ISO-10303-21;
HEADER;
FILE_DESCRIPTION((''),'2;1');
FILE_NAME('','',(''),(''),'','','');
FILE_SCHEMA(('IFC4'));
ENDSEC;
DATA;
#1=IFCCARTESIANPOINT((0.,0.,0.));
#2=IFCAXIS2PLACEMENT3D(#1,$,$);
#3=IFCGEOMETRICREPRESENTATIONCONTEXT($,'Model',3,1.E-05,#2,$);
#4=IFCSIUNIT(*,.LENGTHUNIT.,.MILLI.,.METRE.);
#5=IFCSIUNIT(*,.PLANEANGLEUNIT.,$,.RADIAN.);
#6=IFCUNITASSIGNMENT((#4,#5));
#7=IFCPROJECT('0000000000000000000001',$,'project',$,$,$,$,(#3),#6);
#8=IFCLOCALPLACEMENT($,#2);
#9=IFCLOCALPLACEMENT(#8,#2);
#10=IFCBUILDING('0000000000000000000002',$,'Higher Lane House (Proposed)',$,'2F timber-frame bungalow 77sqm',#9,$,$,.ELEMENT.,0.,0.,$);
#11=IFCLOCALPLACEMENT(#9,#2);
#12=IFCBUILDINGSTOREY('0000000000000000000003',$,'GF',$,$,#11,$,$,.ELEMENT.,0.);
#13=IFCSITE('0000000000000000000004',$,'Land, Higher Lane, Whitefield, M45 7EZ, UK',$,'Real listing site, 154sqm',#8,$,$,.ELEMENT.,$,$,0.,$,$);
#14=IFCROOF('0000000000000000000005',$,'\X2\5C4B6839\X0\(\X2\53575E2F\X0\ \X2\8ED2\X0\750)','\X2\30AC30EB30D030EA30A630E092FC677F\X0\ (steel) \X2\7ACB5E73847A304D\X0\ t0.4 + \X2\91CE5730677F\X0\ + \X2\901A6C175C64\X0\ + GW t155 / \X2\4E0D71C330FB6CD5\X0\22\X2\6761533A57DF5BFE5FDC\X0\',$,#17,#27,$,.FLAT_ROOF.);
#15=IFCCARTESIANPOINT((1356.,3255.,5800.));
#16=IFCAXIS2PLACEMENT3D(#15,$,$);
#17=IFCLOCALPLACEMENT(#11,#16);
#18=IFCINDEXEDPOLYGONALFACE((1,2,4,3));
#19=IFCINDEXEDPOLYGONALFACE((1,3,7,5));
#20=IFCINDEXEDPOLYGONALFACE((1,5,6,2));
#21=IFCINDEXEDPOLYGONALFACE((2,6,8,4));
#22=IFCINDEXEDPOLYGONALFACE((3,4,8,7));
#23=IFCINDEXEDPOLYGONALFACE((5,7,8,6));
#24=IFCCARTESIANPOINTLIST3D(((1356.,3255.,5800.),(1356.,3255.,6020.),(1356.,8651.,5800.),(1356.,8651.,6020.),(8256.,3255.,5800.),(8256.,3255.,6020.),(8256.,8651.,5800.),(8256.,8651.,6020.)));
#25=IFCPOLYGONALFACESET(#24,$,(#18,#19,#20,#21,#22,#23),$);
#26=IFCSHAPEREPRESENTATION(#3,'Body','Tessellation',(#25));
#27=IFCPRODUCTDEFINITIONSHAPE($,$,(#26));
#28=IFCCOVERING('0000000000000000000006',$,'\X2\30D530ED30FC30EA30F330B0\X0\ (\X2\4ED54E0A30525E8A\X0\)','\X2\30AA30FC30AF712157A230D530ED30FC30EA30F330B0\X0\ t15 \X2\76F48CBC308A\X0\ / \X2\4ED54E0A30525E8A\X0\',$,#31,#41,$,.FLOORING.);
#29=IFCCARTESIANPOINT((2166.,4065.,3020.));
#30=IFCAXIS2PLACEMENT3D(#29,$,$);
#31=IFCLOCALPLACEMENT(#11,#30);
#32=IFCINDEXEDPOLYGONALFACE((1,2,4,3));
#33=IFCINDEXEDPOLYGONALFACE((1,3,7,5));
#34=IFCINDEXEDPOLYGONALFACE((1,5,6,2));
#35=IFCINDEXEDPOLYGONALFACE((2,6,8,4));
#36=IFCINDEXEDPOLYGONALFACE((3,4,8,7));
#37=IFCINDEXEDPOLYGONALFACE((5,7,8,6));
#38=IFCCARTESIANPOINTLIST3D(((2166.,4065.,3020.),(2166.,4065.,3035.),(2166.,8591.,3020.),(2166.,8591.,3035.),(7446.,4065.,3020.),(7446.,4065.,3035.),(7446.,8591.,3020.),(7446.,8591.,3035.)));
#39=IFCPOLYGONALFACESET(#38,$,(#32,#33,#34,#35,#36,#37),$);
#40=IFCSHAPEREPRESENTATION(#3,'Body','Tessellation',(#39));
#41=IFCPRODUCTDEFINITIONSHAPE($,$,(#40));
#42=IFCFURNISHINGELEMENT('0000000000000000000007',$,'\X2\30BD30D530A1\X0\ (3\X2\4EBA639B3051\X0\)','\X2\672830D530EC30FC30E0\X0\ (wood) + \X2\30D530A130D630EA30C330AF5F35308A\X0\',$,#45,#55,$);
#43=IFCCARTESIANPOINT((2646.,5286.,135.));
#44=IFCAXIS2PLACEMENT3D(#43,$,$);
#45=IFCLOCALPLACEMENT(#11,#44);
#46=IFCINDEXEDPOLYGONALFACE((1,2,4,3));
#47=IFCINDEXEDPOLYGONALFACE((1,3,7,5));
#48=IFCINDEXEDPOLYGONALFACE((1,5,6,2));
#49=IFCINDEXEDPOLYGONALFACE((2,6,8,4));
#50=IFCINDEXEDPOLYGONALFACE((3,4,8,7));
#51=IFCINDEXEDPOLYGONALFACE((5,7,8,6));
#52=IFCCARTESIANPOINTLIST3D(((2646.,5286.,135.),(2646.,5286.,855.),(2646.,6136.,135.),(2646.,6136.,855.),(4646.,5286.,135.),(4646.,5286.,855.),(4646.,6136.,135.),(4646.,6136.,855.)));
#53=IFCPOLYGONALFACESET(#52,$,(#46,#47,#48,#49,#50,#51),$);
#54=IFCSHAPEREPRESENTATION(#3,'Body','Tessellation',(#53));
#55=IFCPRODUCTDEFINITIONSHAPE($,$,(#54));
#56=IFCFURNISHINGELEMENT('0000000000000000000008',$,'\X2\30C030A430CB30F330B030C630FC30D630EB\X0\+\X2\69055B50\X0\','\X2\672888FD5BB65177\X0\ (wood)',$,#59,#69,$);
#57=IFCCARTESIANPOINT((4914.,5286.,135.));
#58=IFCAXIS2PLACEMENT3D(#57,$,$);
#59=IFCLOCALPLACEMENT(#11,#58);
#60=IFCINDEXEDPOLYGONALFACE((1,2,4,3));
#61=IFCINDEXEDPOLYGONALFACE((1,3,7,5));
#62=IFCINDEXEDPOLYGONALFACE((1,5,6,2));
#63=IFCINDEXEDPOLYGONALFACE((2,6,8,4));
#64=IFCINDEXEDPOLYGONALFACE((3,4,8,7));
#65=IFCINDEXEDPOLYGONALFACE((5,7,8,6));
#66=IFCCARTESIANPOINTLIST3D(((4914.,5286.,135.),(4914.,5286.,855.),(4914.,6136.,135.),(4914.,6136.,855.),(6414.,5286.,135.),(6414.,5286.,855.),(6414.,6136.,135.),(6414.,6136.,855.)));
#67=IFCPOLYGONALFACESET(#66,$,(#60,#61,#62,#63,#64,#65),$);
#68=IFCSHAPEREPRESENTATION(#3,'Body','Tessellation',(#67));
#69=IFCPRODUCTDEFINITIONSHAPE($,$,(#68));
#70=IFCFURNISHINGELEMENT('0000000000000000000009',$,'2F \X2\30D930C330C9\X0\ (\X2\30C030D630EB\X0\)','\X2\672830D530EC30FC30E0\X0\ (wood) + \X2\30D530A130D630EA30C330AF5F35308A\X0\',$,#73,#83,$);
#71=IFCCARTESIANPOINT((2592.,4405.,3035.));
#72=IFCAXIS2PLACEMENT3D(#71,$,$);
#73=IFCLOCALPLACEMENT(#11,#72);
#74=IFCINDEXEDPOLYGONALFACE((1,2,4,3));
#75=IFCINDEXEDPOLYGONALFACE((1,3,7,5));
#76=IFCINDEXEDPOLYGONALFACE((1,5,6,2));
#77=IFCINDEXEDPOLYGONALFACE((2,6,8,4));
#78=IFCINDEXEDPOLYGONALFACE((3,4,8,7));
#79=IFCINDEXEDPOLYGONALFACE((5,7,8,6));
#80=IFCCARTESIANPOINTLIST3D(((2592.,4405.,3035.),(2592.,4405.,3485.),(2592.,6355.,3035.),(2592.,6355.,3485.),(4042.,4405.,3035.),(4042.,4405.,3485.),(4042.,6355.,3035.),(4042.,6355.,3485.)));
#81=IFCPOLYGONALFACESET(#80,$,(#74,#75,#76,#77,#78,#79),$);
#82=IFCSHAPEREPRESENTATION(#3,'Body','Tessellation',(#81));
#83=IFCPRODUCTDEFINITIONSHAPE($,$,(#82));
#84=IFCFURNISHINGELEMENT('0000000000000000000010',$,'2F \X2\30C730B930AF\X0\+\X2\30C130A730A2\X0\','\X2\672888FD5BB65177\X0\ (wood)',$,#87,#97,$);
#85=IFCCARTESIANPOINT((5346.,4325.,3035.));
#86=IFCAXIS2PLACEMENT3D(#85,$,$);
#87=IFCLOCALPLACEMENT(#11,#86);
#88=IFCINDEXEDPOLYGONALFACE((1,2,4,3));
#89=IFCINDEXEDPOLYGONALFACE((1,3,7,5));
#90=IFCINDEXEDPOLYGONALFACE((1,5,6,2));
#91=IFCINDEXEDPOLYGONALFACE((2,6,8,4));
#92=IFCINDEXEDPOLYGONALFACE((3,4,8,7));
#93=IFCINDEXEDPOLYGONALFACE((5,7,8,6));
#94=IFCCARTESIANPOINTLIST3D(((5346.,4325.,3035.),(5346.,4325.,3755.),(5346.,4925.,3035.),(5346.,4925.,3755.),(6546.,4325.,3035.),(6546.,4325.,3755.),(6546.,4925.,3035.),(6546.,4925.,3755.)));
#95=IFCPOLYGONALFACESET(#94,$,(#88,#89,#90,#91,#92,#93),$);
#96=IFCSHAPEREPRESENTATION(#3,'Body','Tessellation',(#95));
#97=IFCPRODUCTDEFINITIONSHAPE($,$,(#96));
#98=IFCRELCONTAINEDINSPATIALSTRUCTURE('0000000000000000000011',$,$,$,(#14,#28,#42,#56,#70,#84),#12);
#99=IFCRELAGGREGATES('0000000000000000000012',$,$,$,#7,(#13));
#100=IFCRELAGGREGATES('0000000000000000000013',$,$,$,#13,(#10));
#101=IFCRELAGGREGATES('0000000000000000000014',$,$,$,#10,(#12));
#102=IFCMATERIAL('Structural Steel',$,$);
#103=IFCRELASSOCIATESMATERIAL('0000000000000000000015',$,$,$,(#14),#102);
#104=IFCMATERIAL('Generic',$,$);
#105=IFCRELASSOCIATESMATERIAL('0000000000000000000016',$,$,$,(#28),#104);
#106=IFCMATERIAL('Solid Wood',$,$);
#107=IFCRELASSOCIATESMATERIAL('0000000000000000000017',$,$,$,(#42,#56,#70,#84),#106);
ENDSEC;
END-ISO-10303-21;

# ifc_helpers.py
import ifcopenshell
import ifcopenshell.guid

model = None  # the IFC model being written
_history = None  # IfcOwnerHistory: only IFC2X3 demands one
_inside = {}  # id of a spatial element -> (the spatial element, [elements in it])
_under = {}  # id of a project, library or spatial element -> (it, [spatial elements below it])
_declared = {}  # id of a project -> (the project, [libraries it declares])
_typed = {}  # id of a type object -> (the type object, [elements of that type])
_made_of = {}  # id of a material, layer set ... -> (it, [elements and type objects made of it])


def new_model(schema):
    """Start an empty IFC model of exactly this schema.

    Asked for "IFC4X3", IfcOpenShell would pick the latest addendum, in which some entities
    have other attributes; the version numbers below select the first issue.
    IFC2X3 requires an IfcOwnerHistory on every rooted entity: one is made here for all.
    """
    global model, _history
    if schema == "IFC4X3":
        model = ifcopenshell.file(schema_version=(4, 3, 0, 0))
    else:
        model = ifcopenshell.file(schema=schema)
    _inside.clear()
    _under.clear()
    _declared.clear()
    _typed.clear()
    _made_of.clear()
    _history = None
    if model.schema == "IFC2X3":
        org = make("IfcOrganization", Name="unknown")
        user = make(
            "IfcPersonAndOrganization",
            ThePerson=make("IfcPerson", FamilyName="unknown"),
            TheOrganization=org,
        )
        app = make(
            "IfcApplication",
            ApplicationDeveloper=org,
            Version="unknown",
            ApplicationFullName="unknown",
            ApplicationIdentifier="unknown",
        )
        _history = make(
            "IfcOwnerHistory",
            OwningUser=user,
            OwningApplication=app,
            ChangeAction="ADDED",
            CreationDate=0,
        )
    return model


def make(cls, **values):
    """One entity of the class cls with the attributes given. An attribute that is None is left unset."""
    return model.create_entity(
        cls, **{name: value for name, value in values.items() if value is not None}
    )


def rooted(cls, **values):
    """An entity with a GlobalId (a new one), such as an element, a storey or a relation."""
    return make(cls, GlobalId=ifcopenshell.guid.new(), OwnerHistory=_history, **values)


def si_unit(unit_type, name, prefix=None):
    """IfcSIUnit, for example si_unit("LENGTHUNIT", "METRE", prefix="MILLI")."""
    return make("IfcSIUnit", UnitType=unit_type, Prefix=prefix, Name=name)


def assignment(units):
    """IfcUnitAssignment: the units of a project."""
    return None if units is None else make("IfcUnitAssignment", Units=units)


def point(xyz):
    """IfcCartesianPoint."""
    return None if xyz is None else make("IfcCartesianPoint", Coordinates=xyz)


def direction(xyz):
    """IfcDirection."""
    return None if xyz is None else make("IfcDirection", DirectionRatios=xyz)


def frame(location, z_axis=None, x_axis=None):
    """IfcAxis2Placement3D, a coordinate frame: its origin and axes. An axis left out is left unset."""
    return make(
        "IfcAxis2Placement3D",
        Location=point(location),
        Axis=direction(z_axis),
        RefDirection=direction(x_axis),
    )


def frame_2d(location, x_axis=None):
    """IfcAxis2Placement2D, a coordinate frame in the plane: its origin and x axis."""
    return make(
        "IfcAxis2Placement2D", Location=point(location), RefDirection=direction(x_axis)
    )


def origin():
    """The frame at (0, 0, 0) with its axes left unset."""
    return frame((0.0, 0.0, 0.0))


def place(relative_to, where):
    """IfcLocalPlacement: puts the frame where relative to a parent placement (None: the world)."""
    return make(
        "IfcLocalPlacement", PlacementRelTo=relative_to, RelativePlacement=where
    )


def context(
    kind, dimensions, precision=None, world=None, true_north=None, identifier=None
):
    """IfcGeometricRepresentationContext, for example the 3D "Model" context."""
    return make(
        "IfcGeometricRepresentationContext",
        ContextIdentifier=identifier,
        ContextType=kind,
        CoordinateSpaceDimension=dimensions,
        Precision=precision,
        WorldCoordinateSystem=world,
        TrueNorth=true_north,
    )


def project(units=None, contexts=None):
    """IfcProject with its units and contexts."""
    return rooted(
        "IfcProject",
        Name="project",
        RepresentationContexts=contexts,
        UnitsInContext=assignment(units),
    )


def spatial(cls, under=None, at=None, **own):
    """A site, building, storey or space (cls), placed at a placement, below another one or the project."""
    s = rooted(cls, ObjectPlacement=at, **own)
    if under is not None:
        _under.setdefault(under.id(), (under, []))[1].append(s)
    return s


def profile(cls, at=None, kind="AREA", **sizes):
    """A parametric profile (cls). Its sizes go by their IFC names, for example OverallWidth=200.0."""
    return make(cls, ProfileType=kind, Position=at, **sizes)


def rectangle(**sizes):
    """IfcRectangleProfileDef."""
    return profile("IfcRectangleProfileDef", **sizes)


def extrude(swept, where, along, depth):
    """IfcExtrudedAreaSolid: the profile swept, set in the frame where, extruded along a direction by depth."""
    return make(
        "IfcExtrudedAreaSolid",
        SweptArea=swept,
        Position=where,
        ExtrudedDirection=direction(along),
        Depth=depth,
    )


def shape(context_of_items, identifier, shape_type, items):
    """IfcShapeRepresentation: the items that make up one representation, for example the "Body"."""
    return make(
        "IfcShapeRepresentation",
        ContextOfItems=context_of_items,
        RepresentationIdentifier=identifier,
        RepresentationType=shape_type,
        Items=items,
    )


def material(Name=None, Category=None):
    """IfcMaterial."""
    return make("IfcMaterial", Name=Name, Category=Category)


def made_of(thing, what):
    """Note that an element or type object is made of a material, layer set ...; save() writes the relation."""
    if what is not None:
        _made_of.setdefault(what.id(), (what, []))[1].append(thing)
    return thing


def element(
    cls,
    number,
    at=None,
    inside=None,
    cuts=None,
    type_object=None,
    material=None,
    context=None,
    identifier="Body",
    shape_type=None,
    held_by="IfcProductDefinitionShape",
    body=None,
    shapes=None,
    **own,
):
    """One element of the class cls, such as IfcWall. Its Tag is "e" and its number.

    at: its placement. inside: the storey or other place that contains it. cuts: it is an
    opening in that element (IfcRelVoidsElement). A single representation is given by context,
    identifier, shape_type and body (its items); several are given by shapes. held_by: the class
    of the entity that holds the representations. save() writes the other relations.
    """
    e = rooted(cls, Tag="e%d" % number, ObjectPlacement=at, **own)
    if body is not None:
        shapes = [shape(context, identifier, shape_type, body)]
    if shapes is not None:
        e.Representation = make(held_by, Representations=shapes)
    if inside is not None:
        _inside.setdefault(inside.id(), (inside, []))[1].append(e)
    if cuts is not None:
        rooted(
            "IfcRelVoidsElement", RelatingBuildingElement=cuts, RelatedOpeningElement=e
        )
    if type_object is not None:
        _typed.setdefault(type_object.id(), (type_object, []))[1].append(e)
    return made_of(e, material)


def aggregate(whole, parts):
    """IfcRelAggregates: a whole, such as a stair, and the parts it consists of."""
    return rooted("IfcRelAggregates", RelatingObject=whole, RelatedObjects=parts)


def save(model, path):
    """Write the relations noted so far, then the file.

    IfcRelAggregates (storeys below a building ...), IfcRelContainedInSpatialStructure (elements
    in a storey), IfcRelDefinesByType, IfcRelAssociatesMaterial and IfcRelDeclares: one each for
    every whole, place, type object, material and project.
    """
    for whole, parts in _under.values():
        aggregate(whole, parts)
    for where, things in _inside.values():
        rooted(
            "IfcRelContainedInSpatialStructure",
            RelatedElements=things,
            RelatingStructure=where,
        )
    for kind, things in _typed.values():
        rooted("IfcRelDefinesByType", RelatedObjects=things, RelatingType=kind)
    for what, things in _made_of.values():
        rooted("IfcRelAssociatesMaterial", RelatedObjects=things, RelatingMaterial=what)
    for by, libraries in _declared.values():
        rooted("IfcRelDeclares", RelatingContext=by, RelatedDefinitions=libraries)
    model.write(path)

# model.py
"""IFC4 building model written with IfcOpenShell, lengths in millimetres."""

from ifc_helpers import new_model, si_unit, frame, frame_2d, origin, place, context, project, spatial, rectangle, extrude, material, element, save


model = new_model("IFC4")

# Units and contexts
model_context = context("Model", 3, precision=1e-05, world=origin())
ifc_project = project(units=[si_unit("LENGTHUNIT", "METRE", prefix="MILLI"), si_unit("PLANEANGLEUNIT", "RADIAN")], contexts=[model_context])

# Site, building, storey
site_placement = place(None, origin())
site = spatial("IfcSite", under=ifc_project, at=site_placement, Name="Land, Higher Lane, Whitefield, M45 7EZ, UK", ObjectType="Real listing site, 154sqm", CompositionType="ELEMENT", RefElevation=0.0)
building_placement = place(site_placement, origin())
building = spatial("IfcBuilding", under=site, at=building_placement, Name="Higher Lane House (Proposed)", ObjectType="2F timber-frame bungalow 77sqm", CompositionType="ELEMENT", ElevationOfRefHeight=0.0, ElevationOfTerrain=0.0)
storey_placement = place(building_placement, origin())
storey = spatial("IfcBuildingStorey", under=building, at=storey_placement, Name="GF", CompositionType="ELEMENT", Elevation=0.0)

# Shared definitions
ifc_material_1 = material(Name="Solid Wood")

# Roof
ifc_material_2 = material(Name="Structural Steel")
for number, where, name in (
    (1, (1356.0, 3255.0, 5800.0), "屋根(南帯 軒750)"),
):
    element("IfcRoof", number, at=place(storey_placement, frame(where)), inside=storey, material=ifc_material_2, Name=name, Description="ガルバリウム鋼板 (steel) 立平葺き t0.4 + 野地板 + 通気層 + GW t155 / 不燃・法22条区域対応", PredefinedType="FLAT_ROOF", context=model_context, shape_type="SweptSolid", body=[
        extrude(rectangle(XDim=6900.0, YDim=5396.0, at=frame_2d((3450.0, 2698.0))), frame((1356.0, 3255.0, 5800.0)), (0.0, 0.0, 1.0), 220.0),
    ])

# Covering
ifc_material_3 = material(Name="Generic")
covering_placement = place(storey_placement, frame((2166.0, 4065.0, 3020.0)))
element("IfcCovering", 2, at=covering_placement, inside=storey, material=ifc_material_3, Name="フローリング (仕上げ床)", Description="オーク無垢フローリング t15 直貼り / 仕上げ床", PredefinedType="FLOORING", context=model_context, shape_type="SweptSolid", body=[
    extrude(rectangle(XDim=5280.0, YDim=4526.0, at=frame_2d((2640.0, 2263.0))), frame((2166.0, 4065.0, 3020.0)), (0.0, 0.0, 1.0), 15.0),
])

# Furnishing elements
furnishing_1_placement = place(storey_placement, frame((2646.0, 5286.0, 135.0)))
element("IfcFurnishingElement", 3, at=furnishing_1_placement, inside=storey, material=ifc_material_1, Name="ソファ (3人掛け)", Description="木フレーム (wood) + ファブリック張り", context=model_context, shape_type="SweptSolid", body=[
    extrude(rectangle(XDim=2000.0, YDim=850.0, at=frame_2d((1000.0, 425.0))), frame((2646.0, 5286.0, 135.0)), (0.0, 0.0, 1.0), 720.0),
])
furnishing_2_placement = place(storey_placement, frame((4914.0, 5286.0, 135.0)))
element("IfcFurnishingElement", 4, at=furnishing_2_placement, inside=storey, material=ifc_material_1, Name="ダイニングテーブル+椅子", Description="木製家具 (wood)", context=model_context, shape_type="SweptSolid", body=[
    extrude(rectangle(XDim=1500.0, YDim=850.0, at=frame_2d((750.0, 425.0))), frame((4914.0, 5286.0, 135.0)), (0.0, 0.0, 1.0), 720.0),
])
furnishing_3_placement = place(storey_placement, frame((2592.0, 4405.0, 3035.0)))
element("IfcFurnishingElement", 5, at=furnishing_3_placement, inside=storey, material=ifc_material_1, Name="2F ベッド (ダブル)", Description="木フレーム (wood) + ファブリック張り", context=model_context, shape_type="SweptSolid", body=[
    extrude(rectangle(XDim=1450.0, YDim=1950.0, at=frame_2d((725.0, 975.0))), frame((2592.0, 4405.0, 3035.0)), (0.0, 0.0, 1.0), 450.0),
])
furnishing_4_placement = place(storey_placement, frame((5346.0, 4325.0, 3035.0)))
element("IfcFurnishingElement", 6, at=furnishing_4_placement, inside=storey, material=ifc_material_1, Name="2F デスク+チェア", Description="木製家具 (wood)", context=model_context, shape_type="SweptSolid", body=[
    extrude(rectangle(XDim=1200.0, YDim=600.0, at=frame_2d((600.0, 300.0))), frame((5346.0, 4325.0, 3035.0)), (0.0, 0.0, 1.0), 720.0),
])

save(model, "model.ifc")
